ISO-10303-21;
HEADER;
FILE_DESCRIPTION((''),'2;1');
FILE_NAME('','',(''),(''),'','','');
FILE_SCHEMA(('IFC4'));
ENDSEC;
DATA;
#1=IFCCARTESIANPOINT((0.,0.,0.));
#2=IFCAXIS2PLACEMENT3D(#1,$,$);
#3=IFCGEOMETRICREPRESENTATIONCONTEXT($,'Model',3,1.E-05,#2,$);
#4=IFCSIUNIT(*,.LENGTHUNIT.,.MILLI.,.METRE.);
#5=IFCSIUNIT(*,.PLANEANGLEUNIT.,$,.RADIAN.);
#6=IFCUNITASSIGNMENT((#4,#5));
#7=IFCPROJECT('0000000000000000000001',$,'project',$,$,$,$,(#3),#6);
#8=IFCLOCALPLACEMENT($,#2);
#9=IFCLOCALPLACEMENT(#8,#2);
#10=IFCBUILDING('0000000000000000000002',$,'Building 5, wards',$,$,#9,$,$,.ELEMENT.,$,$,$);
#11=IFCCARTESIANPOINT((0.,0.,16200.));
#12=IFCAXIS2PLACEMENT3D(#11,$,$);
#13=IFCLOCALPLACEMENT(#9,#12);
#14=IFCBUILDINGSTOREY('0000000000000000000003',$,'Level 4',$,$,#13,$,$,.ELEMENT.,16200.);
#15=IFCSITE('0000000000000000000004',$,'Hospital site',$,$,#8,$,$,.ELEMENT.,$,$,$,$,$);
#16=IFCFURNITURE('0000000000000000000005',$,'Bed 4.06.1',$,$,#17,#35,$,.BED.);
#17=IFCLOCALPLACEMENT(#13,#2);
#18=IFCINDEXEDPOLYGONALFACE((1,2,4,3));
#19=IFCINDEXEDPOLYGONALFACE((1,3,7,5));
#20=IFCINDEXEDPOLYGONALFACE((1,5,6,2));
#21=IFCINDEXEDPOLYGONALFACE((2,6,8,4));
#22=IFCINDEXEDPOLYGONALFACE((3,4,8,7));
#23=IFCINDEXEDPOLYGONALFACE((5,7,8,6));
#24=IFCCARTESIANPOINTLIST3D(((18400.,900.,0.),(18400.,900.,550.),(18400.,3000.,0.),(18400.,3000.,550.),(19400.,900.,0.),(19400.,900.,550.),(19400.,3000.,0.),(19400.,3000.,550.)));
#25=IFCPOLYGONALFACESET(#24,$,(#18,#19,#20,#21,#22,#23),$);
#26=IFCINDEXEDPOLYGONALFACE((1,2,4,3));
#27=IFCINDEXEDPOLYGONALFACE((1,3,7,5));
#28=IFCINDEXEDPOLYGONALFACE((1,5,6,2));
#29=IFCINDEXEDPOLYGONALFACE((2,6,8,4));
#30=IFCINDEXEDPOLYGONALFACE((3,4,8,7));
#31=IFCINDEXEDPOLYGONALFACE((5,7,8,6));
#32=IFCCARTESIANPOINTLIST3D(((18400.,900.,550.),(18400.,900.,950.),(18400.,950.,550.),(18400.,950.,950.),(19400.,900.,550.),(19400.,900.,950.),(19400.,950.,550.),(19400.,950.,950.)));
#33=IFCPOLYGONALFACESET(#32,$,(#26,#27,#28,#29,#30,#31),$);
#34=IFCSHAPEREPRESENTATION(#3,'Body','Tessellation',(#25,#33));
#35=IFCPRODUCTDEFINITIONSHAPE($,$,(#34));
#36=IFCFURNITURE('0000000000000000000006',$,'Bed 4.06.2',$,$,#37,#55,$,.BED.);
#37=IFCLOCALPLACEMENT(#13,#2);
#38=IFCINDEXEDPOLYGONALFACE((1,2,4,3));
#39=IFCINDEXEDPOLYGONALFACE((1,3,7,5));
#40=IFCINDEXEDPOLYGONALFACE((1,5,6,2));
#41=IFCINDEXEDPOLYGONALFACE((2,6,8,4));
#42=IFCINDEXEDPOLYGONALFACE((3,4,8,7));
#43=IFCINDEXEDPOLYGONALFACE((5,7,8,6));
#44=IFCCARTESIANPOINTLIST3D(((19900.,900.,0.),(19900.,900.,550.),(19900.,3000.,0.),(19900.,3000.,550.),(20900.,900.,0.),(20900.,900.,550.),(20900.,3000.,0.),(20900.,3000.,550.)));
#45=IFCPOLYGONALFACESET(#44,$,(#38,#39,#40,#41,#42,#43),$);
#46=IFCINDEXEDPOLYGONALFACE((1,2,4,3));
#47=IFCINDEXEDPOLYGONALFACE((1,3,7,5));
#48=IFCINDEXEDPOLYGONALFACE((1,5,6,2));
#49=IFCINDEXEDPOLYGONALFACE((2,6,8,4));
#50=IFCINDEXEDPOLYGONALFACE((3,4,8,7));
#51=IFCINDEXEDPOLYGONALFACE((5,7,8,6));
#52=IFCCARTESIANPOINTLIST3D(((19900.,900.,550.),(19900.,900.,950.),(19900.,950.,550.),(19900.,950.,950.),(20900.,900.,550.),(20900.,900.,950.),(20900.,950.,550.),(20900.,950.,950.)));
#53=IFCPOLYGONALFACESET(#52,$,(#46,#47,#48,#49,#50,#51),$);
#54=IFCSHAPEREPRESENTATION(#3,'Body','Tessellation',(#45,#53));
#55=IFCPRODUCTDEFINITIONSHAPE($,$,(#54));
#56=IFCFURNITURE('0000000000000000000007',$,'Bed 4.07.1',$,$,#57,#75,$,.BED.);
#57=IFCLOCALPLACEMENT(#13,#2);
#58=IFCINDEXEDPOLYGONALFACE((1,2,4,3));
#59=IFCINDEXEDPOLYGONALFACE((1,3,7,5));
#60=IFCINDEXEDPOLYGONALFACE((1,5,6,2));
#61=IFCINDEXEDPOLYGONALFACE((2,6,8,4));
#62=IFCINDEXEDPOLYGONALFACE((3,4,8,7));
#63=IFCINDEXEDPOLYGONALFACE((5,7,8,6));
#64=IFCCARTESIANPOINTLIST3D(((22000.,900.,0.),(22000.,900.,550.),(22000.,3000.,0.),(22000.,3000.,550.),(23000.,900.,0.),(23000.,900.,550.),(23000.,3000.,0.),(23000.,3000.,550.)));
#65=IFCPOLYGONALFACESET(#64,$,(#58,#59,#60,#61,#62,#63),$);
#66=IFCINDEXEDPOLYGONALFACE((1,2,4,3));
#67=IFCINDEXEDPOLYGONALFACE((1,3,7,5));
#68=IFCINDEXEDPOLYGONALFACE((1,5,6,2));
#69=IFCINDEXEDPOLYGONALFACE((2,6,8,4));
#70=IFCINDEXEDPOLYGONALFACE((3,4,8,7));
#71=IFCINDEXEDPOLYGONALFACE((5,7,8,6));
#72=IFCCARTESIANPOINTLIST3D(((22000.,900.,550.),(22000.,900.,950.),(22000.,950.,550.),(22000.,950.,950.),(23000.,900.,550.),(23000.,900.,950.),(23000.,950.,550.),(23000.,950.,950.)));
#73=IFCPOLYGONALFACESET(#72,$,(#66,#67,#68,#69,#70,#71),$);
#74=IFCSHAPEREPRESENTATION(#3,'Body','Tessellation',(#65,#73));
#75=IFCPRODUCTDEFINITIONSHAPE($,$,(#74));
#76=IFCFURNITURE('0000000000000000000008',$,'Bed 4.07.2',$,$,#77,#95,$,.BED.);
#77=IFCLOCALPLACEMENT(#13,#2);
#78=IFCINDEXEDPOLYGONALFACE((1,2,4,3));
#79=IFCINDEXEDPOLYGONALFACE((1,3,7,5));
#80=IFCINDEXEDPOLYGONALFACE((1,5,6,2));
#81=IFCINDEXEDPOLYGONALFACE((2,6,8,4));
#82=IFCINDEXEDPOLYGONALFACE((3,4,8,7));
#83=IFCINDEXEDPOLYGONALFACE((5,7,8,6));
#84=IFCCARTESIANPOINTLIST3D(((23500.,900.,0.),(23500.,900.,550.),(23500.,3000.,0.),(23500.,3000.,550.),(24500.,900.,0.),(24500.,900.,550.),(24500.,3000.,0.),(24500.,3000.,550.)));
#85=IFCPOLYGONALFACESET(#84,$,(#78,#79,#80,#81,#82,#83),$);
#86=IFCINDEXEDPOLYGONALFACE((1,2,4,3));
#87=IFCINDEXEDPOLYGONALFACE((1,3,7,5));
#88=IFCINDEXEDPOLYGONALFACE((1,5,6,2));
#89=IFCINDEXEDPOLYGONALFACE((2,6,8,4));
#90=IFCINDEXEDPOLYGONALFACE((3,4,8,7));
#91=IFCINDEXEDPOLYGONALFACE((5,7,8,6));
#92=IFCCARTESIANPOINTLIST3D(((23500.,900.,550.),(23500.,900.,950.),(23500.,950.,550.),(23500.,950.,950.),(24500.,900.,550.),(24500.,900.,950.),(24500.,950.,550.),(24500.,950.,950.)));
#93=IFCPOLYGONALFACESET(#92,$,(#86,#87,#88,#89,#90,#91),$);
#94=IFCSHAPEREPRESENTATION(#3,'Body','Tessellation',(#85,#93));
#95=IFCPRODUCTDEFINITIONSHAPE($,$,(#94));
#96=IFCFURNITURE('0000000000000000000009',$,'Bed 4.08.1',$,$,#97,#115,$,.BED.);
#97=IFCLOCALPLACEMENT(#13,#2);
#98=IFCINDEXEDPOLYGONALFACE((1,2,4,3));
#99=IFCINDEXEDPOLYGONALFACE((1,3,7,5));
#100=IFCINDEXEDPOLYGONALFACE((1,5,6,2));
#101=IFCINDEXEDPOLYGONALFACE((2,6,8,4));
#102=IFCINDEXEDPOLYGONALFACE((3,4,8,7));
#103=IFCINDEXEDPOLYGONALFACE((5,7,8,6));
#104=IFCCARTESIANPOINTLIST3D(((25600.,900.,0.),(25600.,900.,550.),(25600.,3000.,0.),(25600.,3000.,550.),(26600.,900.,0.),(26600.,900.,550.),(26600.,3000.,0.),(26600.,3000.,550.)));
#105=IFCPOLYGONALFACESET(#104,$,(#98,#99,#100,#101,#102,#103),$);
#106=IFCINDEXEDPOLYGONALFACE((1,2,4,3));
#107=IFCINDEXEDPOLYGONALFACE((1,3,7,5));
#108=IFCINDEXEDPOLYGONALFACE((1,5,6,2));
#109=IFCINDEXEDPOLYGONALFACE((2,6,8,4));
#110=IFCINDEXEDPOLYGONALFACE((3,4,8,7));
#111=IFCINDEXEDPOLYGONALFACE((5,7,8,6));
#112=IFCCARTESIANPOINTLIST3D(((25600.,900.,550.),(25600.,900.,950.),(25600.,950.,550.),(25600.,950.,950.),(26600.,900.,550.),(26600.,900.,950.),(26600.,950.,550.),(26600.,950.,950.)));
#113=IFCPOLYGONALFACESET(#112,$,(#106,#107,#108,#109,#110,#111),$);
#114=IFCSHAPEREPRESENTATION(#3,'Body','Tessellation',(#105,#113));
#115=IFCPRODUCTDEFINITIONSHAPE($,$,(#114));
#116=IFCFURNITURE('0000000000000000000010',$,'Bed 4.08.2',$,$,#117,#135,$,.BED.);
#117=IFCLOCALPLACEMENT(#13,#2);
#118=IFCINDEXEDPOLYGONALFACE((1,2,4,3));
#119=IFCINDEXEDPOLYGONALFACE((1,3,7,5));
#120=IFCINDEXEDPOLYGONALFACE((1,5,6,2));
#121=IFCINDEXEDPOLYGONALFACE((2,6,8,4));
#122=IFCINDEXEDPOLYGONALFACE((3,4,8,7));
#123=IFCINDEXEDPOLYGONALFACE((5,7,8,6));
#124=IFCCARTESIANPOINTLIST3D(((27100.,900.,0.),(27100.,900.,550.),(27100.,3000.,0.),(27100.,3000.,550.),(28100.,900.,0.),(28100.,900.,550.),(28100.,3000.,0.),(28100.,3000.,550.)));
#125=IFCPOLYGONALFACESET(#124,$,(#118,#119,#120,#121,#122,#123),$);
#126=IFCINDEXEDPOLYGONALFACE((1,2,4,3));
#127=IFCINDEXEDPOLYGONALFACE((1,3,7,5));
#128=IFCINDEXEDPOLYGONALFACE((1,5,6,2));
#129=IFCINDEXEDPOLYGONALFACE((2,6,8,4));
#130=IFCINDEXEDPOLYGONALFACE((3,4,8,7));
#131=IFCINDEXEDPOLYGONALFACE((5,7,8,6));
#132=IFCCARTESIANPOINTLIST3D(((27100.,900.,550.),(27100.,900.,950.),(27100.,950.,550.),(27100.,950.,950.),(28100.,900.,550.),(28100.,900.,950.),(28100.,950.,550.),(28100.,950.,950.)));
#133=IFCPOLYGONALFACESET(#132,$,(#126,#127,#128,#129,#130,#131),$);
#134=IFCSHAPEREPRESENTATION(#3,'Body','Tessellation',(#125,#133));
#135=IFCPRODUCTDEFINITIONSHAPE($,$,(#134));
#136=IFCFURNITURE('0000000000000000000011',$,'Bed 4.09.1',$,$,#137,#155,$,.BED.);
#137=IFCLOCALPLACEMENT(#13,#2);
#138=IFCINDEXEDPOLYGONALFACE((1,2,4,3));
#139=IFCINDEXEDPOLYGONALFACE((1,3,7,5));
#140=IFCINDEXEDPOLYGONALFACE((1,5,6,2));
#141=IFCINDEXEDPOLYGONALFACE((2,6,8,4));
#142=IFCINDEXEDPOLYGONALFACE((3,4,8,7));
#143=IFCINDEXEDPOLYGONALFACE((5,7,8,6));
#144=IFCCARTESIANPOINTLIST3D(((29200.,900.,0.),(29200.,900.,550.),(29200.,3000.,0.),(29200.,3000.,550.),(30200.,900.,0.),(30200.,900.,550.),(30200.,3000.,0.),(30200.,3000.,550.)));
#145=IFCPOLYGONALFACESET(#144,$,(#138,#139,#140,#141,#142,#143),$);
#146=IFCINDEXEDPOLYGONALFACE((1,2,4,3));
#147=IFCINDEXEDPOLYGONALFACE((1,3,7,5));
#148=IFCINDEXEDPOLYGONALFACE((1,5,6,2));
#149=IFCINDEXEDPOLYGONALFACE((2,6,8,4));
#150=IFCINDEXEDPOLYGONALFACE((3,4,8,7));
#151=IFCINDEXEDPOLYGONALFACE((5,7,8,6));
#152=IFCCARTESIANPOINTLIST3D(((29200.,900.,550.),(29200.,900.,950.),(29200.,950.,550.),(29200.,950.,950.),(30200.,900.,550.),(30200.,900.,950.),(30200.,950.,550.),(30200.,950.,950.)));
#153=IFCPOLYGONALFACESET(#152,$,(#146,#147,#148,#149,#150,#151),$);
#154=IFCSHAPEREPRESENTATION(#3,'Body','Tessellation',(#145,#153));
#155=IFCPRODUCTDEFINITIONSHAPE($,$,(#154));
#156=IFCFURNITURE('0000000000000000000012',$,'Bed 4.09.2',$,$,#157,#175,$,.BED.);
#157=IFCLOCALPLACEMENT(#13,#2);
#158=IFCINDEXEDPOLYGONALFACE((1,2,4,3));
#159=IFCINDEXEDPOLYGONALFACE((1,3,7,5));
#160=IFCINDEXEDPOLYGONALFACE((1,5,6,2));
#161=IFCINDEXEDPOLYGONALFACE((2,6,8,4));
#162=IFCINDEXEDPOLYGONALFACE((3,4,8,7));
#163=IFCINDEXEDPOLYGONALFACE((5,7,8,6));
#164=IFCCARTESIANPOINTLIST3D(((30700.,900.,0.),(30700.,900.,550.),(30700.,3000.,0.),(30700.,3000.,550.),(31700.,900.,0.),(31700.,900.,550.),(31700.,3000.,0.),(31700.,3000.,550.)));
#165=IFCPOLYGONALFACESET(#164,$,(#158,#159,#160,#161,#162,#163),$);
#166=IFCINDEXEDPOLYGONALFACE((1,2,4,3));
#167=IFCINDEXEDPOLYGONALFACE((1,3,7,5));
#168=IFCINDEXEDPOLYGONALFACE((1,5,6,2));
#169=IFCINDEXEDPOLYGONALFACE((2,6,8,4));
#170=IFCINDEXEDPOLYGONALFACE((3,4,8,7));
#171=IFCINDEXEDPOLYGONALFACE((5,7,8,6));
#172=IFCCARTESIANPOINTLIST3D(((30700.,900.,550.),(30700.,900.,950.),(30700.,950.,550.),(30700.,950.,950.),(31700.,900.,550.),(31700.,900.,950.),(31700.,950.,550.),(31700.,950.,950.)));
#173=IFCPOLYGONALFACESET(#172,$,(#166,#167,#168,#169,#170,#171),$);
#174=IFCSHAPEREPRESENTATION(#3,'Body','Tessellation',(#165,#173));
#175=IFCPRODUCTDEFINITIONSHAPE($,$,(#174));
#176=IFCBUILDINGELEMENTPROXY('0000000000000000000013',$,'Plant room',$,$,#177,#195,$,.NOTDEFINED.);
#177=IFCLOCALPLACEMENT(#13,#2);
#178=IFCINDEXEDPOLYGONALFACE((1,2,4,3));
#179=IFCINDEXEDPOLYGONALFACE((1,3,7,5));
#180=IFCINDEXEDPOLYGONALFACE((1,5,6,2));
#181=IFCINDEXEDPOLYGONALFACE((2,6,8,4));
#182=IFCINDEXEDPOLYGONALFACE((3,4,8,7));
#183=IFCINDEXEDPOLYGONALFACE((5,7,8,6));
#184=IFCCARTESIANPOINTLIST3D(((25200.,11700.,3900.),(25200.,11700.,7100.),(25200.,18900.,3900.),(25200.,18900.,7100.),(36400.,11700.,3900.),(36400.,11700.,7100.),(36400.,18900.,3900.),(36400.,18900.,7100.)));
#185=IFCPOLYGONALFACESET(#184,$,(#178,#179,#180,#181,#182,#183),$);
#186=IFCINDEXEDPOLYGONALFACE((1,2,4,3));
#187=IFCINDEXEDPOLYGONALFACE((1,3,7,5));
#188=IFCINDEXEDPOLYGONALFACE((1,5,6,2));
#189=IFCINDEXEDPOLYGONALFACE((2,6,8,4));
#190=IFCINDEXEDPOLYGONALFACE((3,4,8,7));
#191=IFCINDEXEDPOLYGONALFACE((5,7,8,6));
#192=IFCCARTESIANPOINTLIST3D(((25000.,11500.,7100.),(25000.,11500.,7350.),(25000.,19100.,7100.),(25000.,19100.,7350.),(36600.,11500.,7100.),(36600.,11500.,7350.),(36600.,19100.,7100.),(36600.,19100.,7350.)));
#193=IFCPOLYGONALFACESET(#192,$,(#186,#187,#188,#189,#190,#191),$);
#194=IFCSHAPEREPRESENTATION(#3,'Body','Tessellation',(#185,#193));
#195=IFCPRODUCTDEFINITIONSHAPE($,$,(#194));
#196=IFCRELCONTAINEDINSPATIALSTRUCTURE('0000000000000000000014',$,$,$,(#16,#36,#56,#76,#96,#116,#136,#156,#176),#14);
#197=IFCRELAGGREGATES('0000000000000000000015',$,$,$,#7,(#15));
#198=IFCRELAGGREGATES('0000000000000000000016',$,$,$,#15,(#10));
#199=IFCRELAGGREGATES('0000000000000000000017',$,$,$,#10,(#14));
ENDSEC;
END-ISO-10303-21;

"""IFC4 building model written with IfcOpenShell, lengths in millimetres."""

from ifc_helpers import new_model, si_unit, frame, frame_2d, origin, place, context, project, spatial, rectangle, extrude, element, save


model = new_model("IFC4")

# Units and contexts
model_context = context("Model", 3, precision=1e-05, world=origin())
ifc_project = project(units=[si_unit("LENGTHUNIT", "METRE", prefix="MILLI"), si_unit("PLANEANGLEUNIT", "RADIAN")], contexts=[model_context])

# Site, building, storey
site_placement = place(None, origin())
site = spatial("IfcSite", under=ifc_project, at=site_placement, Name="Hospital site", CompositionType="ELEMENT")
building_placement = place(site_placement, origin())
building = spatial("IfcBuilding", under=site, at=building_placement, Name="Building 5, wards", CompositionType="ELEMENT")
storey_placement = place(building_placement, frame((0.0, 0.0, 16200.0)))
storey = spatial("IfcBuildingStorey", under=building, at=storey_placement, Name="Level 4", CompositionType="ELEMENT", Elevation=16200.0)

# Furniture
for number, where, name in (
    (1, (18400.0, 900.0, 0.0), "Bed 4.06.1"),
    (2, (19900.0, 900.0, 0.0), "Bed 4.06.2"),
    (3, (22000.0, 900.0, 0.0), "Bed 4.07.1"),
    (4, (23500.0, 900.0, 0.0), "Bed 4.07.2"),
    (5, (25600.0, 900.0, 0.0), "Bed 4.08.1"),
    (6, (27100.0, 900.0, 0.0), "Bed 4.08.2"),
    (7, (29200.0, 900.0, 0.0), "Bed 4.09.1"),
    (8, (30700.0, 900.0, 0.0), "Bed 4.09.2"),
):
    element("IfcFurniture", number, at=place(storey_placement, frame(where)), inside=storey, Name=name, PredefinedType="BED", context=model_context, shape_type="SweptSolid", body=[
        extrude(rectangle(XDim=1000.0, YDim=2100.0, at=frame_2d((500.0, 1050.0))), origin(), (0.0, 0.0, 1.0), 550.0),
        extrude(rectangle(XDim=1000.0, YDim=50.0, at=frame_2d((500.0, 25.0))), frame((0.0, 0.0, 550.0)), (0.0, 0.0, 1.0), 400.0),
    ])

# Building element proxy
proxy_placement = place(storey_placement, frame((25200.0, 11700.0, 3900.0)))
element("IfcBuildingElementProxy", 9, at=proxy_placement, inside=storey, Name="Plant room", PredefinedType="NOTDEFINED", context=model_context, shape_type="SweptSolid", body=[
    extrude(rectangle(XDim=11200.0, YDim=7200.0, at=frame_2d((5600.0, 3600.0))), origin(), (0.0, 0.0, 1.0), 3200.0),
    extrude(rectangle(XDim=11600.0, YDim=7600.0, at=frame_2d((5600.0, 3600.0))), frame((0.0, 0.0, 3200.0)), (0.0, 0.0, 1.0), 250.0),
])

save(model, "model.ifc")
